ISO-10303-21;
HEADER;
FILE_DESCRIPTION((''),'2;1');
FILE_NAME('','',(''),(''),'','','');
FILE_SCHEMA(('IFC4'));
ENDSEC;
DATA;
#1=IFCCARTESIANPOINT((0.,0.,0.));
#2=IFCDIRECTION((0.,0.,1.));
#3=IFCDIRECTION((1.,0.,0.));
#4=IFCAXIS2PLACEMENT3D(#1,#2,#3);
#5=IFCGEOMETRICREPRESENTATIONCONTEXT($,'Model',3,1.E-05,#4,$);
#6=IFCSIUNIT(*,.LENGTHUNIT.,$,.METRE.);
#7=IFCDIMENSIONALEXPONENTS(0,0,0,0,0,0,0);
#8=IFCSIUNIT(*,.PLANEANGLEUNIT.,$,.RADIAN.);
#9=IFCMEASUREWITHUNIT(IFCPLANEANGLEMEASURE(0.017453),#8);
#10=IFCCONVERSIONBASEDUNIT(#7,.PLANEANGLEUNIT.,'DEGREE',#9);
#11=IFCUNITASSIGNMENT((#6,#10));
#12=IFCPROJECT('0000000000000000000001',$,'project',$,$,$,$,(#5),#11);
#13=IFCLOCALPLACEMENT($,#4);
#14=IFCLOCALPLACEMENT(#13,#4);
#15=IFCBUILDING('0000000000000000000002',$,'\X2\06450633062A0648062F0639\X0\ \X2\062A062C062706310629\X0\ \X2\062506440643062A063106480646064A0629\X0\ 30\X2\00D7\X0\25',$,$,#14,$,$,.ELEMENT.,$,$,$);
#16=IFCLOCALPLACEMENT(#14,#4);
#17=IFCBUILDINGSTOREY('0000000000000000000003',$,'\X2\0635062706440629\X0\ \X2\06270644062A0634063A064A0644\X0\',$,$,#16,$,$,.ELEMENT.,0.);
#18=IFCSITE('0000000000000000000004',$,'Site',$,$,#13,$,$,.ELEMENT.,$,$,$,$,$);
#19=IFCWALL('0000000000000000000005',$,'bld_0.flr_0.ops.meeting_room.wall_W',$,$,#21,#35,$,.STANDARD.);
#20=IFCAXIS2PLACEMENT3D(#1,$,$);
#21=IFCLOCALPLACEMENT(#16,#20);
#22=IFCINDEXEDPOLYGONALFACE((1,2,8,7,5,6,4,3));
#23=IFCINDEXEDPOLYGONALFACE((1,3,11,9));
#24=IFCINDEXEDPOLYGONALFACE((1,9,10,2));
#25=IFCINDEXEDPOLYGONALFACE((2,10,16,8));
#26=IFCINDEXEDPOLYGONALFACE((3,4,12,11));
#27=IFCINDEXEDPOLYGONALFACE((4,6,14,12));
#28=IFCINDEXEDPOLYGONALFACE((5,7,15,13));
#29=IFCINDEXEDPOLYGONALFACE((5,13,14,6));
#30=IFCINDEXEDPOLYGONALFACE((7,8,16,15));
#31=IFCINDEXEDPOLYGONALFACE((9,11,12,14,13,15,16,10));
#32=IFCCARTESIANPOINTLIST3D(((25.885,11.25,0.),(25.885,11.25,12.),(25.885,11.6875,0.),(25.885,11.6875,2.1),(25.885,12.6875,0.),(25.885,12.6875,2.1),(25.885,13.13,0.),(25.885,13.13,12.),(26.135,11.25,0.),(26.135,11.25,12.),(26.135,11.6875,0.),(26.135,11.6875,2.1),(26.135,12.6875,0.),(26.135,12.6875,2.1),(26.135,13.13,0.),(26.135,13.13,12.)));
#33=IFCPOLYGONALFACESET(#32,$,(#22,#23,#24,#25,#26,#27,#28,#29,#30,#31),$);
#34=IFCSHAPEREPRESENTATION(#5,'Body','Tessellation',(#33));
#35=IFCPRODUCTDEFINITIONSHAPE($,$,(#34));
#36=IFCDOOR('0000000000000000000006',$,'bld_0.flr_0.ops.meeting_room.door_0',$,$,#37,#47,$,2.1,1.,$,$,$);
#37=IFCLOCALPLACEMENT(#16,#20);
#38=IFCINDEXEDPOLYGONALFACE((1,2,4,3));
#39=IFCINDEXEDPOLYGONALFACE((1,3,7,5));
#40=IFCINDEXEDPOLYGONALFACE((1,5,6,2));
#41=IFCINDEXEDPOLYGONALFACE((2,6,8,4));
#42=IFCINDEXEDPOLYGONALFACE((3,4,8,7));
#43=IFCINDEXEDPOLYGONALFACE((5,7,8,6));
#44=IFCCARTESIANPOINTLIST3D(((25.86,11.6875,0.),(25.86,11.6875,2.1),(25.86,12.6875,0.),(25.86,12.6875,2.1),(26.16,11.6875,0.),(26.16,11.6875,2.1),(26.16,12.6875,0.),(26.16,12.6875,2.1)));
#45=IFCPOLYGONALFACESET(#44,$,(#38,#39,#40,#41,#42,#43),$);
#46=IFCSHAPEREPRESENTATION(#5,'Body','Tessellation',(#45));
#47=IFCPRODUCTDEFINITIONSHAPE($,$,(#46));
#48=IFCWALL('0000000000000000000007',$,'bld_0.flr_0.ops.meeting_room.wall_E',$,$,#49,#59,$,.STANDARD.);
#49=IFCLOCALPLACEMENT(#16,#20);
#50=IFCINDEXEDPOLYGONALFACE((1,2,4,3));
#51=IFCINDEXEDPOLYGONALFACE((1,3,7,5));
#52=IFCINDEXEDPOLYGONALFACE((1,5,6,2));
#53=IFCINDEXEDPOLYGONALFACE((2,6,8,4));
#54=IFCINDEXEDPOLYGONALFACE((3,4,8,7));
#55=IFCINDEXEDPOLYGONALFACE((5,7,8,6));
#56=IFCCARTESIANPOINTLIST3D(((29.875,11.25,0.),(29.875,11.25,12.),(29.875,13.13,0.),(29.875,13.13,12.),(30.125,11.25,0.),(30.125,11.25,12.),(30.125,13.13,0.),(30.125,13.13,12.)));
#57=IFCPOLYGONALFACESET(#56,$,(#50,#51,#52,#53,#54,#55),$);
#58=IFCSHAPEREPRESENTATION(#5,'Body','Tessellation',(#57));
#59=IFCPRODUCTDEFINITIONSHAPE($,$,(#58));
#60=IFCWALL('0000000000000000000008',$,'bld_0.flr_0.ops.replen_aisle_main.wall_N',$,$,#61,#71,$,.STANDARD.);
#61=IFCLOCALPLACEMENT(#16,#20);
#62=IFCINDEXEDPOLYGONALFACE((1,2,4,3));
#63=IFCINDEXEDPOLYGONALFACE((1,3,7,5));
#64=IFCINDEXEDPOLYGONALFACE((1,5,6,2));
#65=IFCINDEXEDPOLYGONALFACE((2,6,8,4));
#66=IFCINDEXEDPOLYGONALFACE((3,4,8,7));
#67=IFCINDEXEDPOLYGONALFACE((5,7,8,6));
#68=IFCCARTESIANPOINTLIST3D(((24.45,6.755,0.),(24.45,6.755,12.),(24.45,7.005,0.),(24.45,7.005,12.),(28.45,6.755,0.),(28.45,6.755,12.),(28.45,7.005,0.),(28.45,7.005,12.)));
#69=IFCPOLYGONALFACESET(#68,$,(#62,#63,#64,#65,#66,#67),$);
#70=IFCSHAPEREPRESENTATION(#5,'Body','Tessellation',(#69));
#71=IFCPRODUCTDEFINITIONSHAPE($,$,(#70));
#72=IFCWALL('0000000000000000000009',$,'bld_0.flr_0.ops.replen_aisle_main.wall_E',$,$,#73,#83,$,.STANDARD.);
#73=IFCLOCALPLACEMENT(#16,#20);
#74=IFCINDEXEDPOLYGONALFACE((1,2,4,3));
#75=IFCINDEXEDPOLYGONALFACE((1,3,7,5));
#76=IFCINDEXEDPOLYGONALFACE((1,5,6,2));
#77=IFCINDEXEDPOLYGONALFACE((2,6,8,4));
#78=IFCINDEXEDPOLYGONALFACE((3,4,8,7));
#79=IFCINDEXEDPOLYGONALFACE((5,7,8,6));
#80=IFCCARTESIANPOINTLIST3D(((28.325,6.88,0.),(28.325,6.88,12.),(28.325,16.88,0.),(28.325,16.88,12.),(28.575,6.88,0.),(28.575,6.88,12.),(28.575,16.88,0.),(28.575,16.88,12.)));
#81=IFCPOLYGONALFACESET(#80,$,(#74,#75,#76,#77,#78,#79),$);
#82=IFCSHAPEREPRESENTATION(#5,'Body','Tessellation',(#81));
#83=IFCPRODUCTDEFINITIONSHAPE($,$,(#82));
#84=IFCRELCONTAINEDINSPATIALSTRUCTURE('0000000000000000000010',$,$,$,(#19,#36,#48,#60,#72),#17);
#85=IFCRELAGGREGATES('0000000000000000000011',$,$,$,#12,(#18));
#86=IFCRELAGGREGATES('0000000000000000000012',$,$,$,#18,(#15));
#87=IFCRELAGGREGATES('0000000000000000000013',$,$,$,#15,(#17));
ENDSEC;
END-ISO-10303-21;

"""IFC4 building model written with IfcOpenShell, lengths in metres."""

from ifc_helpers import new_model, entity, si_unit, converted_unit, frame, frame_2d, origin_with_axes, origin_2d_with_axis, place, context, project, spatial, rectangle, extrude, element, fill, save


model = new_model("IFC4")

# Units and contexts
model_context = context("Model", 3, precision=1e-05, world=origin_with_axes())
ifc_project = project(units=[si_unit("LENGTHUNIT", "METRE"), converted_unit("PLANEANGLEUNIT", "DEGREE", entity("IfcPlaneAngleMeasure", 0.017453), si_unit("PLANEANGLEUNIT", "RADIAN"), dimensions=[0, 0, 0, 0, 0, 0, 0])], contexts=[model_context])

# Site, building, storey
site_placement = place(None, origin_with_axes())
site = spatial("IfcSite", under=ifc_project, at=site_placement, Name="Site", CompositionType="ELEMENT")
building_placement = place(site_placement, origin_with_axes())
building = spatial("IfcBuilding", under=site, at=building_placement, Name="مستودع تجارة إلكترونية 30×25", CompositionType="ELEMENT")
storey_placement = place(building_placement, origin_with_axes())
storey = spatial("IfcBuildingStorey", under=building, at=storey_placement, Name="صالة التشغيل", CompositionType="ELEMENT", Elevation=0.0)

# Wall, opening, door
wall_1_placement = place(storey_placement, frame((26.01, 11.25, 0.0), z_axis=(0.0, 0.0, 1.0), x_axis=(0.0, 1.0, 0.0)))
wall_1 = element("IfcWall", 1, at=wall_1_placement, inside=storey, Name="bld_0.flr_0.ops.meeting_room.wall_W", PredefinedType="STANDARD", context=model_context, shape_type="SweptSolid", body=[
    extrude(rectangle(XDim=1.88, YDim=0.25, at=frame_2d((0.94, 0.0), x_axis=(1.0, 0.0))), origin_with_axes(), (0.0, 0.0, 1.0), 12.0),
])
opening_1_placement = place(storey_placement, frame((26.01, 12.1875, 0.0), z_axis=(0.0, 0.0, 1.0), x_axis=(0.0, 1.0, 0.0)))
opening_1 = element("IfcOpeningElement", 2, at=opening_1_placement, cuts=wall_1, PredefinedType="OPENING", context=model_context, shape_type="SweptSolid", body=[
    extrude(rectangle(XDim=1.0, YDim=0.3, at=origin_2d_with_axis()), origin_with_axes(), (0.0, 0.0, 1.0), 2.1),
])
door_1_placement = place(storey_placement, frame((26.01, 12.1875, 0.0), z_axis=(0.0, 0.0, 1.0), x_axis=(0.0, 1.0, 0.0)))
door_1 = element("IfcDoor", 3, at=door_1_placement, inside=storey, Name="bld_0.flr_0.ops.meeting_room.door_0", OverallHeight=2.1, OverallWidth=1.0, context=model_context, shape_type="SweptSolid", body=[
    extrude(rectangle(XDim=1.0, YDim=0.3, at=origin_2d_with_axis()), origin_with_axes(), (0.0, 0.0, 1.0), 2.1),
])
fill(opening_1, door_1)

# Walls
wall_2_placement = place(storey_placement, frame((30.0, 11.25, 0.0), z_axis=(0.0, 0.0, 1.0), x_axis=(0.0, 1.0, 0.0)))
element("IfcWall", 4, at=wall_2_placement, inside=storey, Name="bld_0.flr_0.ops.meeting_room.wall_E", PredefinedType="STANDARD", context=model_context, shape_type="SweptSolid", body=[
    extrude(rectangle(XDim=1.88, YDim=0.25, at=frame_2d((0.94, 0.0), x_axis=(1.0, 0.0))), origin_with_axes(), (0.0, 0.0, 1.0), 12.0),
])
wall_3_placement = place(storey_placement, frame((24.45, 6.88, 0.0), z_axis=(0.0, 0.0, 1.0), x_axis=(1.0, 0.0, 0.0)))
element("IfcWall", 5, at=wall_3_placement, inside=storey, Name="bld_0.flr_0.ops.replen_aisle_main.wall_N", PredefinedType="STANDARD", context=model_context, shape_type="SweptSolid", body=[
    extrude(rectangle(XDim=4.0, YDim=0.25, at=frame_2d((2.0, 0.0), x_axis=(1.0, 0.0))), origin_with_axes(), (0.0, 0.0, 1.0), 12.0),
])
for number, where, z_axis, x_axis, name in (
    (6, (28.45, 6.88, 0.0), (0.0, 0.0, 1.0), (0.0, 1.0, 0.0), "bld_0.flr_0.ops.replen_aisle_main.wall_E"),
):
    element("IfcWall", number, at=place(storey_placement, frame(where, z_axis=z_axis, x_axis=x_axis)), inside=storey, Name=name, PredefinedType="STANDARD", context=model_context, shape_type="SweptSolid", body=[
        extrude(rectangle(XDim=10.0, YDim=0.25, at=frame_2d((5.0, 0.0), x_axis=(1.0, 0.0))), origin_with_axes(), (0.0, 0.0, 1.0), 12.0),
    ])

save(model, "model.ifc")
